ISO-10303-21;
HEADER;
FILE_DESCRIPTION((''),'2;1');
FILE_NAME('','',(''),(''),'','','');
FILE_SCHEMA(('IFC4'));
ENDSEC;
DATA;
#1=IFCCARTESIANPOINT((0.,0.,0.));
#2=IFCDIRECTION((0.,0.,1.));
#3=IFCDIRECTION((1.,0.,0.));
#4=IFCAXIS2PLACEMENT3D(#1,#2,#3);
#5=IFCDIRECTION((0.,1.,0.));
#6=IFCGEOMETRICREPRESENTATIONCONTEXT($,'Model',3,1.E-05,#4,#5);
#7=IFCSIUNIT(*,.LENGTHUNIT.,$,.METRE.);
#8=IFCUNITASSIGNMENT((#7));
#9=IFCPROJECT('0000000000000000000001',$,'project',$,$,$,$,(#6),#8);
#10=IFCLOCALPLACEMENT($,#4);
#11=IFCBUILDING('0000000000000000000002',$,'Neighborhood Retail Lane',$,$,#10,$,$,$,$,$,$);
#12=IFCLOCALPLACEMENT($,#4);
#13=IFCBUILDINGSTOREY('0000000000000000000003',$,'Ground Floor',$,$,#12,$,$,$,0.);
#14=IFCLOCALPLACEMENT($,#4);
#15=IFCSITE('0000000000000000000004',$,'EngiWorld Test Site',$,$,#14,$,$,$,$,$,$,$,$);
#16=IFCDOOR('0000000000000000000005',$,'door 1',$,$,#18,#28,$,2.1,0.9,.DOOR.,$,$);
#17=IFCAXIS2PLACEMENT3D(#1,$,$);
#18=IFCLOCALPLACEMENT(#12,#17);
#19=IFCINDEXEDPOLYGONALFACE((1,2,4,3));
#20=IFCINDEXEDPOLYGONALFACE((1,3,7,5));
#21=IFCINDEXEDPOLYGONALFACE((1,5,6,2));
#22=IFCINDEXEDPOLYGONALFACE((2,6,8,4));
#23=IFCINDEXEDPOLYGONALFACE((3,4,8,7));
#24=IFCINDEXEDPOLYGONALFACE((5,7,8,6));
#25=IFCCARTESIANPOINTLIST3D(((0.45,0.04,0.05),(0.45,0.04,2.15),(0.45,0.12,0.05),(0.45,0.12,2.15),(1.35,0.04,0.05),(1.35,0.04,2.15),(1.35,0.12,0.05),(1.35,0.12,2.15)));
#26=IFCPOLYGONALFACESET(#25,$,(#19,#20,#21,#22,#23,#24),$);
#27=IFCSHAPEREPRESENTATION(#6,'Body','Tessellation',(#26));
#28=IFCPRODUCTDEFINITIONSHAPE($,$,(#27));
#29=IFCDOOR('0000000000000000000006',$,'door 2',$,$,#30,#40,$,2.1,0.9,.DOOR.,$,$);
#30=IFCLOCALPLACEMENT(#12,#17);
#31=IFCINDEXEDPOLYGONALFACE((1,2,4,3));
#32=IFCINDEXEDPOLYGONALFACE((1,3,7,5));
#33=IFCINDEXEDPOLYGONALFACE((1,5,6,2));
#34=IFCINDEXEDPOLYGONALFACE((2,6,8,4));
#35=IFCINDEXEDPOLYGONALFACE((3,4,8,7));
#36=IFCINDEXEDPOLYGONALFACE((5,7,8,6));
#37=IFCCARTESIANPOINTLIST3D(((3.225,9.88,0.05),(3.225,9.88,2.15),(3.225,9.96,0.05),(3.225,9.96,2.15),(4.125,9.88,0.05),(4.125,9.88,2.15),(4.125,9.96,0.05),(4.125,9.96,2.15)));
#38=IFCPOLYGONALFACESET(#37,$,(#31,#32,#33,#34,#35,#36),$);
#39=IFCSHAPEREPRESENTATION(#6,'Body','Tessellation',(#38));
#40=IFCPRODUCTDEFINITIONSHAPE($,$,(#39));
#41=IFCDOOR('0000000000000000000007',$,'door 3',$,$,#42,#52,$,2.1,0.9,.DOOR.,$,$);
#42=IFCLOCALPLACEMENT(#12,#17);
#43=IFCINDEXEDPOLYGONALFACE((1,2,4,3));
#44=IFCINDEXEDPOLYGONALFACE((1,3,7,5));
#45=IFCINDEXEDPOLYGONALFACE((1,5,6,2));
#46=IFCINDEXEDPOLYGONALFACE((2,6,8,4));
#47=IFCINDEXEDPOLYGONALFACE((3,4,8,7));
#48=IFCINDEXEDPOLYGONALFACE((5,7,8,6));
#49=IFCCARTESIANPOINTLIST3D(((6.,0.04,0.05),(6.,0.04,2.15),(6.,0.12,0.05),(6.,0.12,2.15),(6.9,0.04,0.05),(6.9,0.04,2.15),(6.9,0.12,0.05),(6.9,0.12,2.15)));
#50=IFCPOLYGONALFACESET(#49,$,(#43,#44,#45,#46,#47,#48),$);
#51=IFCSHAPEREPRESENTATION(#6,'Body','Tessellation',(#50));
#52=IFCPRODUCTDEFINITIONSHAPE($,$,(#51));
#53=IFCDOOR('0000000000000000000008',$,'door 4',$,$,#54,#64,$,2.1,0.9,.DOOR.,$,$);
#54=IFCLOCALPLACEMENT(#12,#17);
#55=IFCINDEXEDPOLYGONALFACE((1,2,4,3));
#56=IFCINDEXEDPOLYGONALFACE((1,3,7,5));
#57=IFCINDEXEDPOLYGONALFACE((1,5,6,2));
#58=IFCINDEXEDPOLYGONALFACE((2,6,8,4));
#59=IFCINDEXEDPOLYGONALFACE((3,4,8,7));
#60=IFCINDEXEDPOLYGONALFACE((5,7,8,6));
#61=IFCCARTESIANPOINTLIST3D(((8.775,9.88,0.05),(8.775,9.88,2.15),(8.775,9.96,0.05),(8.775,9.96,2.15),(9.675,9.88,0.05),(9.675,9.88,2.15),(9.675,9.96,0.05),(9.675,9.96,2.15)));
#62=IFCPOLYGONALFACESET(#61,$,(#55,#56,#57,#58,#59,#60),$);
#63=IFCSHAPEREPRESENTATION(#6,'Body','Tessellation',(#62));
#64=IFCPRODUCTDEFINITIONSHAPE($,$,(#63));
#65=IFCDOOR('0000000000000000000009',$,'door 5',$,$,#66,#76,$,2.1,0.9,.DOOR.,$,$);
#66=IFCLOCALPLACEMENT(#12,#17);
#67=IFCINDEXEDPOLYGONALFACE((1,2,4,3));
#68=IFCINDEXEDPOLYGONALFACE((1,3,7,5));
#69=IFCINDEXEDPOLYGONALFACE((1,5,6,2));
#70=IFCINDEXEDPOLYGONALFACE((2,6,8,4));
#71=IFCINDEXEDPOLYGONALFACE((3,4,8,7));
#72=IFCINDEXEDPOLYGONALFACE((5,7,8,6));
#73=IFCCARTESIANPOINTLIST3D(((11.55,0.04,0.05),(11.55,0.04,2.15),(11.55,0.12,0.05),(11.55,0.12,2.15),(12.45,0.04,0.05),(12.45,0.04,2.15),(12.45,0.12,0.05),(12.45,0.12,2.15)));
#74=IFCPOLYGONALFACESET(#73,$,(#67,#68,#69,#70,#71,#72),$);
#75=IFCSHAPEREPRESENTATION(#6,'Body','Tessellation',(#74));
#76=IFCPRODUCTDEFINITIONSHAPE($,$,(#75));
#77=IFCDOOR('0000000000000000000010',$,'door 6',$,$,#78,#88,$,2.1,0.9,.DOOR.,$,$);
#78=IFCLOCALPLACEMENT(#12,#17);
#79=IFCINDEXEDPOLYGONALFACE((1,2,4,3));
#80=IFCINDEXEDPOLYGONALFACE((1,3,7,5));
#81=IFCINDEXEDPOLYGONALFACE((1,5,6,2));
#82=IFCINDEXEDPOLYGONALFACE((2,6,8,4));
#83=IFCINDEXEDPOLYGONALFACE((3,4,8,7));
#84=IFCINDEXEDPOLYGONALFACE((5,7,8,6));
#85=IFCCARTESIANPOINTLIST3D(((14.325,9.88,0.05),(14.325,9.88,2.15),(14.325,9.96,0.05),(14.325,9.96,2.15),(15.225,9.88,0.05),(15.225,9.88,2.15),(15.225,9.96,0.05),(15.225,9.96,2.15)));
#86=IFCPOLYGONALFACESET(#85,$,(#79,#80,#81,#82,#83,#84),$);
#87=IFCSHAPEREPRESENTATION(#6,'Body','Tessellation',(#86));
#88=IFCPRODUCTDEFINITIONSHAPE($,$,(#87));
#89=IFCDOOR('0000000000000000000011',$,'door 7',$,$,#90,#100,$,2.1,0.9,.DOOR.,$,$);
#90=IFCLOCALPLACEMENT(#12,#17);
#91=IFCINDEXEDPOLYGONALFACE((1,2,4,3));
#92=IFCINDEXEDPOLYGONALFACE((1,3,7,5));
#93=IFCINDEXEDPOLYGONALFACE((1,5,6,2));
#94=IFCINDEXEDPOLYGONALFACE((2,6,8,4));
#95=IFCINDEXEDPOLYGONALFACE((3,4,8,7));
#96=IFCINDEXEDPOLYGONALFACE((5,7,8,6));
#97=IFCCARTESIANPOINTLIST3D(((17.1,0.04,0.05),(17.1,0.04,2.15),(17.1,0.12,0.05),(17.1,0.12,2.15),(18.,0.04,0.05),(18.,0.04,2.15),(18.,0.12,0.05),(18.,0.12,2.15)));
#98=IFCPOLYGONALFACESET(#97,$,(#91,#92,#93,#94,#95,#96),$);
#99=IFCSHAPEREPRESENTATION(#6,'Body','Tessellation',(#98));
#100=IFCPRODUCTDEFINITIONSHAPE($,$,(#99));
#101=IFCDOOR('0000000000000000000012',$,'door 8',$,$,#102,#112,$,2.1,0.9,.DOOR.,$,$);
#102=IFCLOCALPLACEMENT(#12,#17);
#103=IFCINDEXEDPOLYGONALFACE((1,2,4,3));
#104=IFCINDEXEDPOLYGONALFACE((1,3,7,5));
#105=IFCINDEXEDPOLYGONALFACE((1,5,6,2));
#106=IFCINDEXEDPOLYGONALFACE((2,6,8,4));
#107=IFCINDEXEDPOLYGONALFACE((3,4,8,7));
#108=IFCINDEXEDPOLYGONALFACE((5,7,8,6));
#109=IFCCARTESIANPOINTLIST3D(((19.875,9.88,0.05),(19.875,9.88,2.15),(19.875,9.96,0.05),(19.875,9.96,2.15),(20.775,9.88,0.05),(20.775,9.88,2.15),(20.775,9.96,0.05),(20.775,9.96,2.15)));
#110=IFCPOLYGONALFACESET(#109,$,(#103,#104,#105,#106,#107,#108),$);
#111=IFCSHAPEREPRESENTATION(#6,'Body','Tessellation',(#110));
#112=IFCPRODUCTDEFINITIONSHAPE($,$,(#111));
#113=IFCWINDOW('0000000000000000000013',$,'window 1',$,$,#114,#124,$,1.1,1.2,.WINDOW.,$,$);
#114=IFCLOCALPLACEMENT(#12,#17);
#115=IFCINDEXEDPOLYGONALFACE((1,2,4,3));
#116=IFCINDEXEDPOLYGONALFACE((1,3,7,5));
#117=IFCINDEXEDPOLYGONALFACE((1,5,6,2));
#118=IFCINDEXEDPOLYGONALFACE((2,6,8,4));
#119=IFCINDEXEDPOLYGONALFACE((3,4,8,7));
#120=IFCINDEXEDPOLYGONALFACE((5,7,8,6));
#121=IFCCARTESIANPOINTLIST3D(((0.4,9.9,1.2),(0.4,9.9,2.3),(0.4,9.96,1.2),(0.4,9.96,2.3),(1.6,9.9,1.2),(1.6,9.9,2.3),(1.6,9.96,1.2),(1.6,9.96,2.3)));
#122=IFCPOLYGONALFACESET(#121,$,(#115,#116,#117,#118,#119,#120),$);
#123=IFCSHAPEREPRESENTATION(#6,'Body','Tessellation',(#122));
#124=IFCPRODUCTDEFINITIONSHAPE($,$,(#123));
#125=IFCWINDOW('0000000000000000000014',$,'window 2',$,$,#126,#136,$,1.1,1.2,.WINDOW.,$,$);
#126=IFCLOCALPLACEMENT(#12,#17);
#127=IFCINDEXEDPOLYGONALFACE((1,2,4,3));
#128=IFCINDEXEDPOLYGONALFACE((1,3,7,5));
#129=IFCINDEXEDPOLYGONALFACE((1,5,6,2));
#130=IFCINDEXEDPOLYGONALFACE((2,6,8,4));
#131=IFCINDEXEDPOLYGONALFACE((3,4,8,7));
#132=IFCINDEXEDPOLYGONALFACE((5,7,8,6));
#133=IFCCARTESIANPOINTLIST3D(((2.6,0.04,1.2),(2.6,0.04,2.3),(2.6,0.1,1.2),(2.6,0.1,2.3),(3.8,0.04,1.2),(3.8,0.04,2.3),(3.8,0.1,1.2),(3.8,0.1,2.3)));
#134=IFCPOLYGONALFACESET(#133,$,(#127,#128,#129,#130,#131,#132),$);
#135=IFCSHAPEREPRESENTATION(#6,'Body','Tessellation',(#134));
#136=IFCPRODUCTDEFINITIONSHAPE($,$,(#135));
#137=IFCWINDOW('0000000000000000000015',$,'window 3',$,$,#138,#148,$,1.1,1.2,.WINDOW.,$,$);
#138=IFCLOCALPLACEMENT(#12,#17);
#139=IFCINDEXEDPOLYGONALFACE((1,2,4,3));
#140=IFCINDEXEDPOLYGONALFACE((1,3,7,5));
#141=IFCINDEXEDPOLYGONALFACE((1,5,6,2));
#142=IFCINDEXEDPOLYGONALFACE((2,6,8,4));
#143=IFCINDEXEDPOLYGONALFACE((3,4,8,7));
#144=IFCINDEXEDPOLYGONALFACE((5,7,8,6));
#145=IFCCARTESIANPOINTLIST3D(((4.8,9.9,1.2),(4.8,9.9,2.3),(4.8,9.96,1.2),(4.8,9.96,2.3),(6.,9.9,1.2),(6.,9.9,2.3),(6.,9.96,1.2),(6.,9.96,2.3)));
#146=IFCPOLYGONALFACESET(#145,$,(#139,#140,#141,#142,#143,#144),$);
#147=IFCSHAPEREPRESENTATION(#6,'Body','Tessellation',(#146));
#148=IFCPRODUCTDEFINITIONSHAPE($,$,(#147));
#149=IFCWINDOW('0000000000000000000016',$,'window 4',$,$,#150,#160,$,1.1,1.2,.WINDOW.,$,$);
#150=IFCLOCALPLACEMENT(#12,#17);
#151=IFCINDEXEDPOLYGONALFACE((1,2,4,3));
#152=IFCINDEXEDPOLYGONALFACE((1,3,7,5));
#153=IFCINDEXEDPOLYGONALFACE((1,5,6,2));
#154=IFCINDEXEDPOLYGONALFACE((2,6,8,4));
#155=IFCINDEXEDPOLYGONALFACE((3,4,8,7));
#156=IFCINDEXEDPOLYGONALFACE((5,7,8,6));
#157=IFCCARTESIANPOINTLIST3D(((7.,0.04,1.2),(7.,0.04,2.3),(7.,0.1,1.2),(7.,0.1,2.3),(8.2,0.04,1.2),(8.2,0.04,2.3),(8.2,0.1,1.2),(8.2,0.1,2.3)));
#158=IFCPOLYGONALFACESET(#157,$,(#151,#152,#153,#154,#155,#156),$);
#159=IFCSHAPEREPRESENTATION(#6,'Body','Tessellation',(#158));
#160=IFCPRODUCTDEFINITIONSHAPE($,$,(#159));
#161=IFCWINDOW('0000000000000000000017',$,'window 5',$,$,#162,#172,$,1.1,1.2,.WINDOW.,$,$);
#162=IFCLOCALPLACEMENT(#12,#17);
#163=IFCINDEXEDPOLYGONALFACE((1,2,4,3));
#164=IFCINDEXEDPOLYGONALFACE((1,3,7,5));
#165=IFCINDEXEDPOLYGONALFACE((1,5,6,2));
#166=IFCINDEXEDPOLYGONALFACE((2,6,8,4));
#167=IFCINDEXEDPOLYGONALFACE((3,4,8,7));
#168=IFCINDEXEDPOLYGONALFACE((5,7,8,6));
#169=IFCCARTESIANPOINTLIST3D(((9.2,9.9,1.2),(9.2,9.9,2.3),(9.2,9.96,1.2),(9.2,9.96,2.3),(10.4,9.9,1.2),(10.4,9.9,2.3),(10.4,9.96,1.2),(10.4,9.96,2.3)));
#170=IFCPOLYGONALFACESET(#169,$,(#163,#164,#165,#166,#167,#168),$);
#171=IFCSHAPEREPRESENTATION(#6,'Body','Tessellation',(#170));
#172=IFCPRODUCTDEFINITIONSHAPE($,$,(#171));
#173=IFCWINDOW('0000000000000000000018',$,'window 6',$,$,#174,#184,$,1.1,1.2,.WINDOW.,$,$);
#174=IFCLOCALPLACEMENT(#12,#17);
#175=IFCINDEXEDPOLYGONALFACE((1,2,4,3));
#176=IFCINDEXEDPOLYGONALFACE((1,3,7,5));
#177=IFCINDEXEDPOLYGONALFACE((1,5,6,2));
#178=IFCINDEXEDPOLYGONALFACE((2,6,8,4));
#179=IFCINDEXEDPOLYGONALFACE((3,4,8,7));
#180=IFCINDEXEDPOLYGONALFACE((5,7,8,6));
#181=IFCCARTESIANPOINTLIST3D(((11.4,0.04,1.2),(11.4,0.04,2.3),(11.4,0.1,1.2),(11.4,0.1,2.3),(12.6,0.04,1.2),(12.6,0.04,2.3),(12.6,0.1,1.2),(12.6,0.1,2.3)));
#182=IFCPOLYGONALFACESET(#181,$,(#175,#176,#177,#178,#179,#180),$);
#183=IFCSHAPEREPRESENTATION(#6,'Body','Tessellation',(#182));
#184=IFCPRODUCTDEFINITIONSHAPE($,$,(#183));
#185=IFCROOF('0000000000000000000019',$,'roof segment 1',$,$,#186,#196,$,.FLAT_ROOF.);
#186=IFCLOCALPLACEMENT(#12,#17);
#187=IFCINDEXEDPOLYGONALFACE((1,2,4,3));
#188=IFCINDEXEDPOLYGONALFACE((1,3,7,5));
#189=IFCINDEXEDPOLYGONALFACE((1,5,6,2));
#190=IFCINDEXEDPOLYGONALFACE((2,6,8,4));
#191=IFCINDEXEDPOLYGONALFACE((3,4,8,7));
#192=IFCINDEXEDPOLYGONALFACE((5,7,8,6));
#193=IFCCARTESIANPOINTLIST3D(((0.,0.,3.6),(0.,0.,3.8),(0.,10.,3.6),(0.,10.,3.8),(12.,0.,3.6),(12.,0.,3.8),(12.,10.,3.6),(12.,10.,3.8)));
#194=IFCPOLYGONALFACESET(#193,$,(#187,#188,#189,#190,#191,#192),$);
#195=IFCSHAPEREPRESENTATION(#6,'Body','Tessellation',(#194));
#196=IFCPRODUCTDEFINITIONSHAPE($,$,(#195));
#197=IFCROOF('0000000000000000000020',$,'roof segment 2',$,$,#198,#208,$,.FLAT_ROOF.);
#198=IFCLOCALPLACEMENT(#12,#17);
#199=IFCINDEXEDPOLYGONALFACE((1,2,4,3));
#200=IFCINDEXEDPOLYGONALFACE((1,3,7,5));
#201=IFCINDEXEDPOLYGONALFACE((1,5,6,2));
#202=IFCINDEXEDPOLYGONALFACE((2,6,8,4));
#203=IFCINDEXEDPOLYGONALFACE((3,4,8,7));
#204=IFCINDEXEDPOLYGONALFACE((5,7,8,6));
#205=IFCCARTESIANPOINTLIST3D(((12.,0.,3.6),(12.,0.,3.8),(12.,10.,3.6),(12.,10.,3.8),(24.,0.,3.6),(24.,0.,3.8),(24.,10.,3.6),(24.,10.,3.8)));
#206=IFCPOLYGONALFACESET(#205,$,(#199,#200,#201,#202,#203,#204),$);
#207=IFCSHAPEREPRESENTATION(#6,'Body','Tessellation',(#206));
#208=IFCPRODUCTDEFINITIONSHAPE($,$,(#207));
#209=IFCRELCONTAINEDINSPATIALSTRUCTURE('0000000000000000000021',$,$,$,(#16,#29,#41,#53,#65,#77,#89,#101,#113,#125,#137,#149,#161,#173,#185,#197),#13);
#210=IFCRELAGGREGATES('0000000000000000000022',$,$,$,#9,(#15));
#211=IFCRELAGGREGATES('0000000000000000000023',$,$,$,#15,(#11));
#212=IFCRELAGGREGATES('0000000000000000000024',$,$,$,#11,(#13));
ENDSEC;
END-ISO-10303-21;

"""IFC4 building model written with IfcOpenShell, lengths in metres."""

from ifc_helpers import new_model, si_unit, direction, frame, origin_with_axes, origin_2d_with_axis, place, context, project, spatial, rectangle, extrude, element, save


model = new_model("IFC4")

# Units and contexts
model_context = context("Model", 3, precision=1e-05, world=origin_with_axes(), true_north=direction((0.0, 1.0, 0.0)))
ifc_project = project(units=[si_unit("LENGTHUNIT", "METRE")], contexts=[model_context])

# Site, building, storey
site_placement = place(None, origin_with_axes())
site = spatial("IfcSite", under=ifc_project, at=site_placement, Name="EngiWorld Test Site")
building_placement = place(None, origin_with_axes())
building = spatial("IfcBuilding", under=site, at=building_placement, Name="Neighborhood Retail Lane")
storey_placement = place(None, origin_with_axes())
storey = spatial("IfcBuildingStorey", under=building, at=storey_placement, Name="Ground Floor", Elevation=0.0)

# Doors
for number, where, z_axis, x_axis, name in (
    (1, (0.9, 0.08, 0.05), (0.0, 0.0, 1.0), (1.0, 0.0, 0.0), "door 1"),
    (2, (3.675, 9.92, 0.05), (0.0, 0.0, 1.0), (1.0, 0.0, 0.0), "door 2"),
    (3, (6.45, 0.08, 0.05), (0.0, 0.0, 1.0), (1.0, 0.0, 0.0), "door 3"),
    (4, (9.225, 9.92, 0.05), (0.0, 0.0, 1.0), (1.0, 0.0, 0.0), "door 4"),
    (5, (12.0, 0.08, 0.05), (0.0, 0.0, 1.0), (1.0, 0.0, 0.0), "door 5"),
    (6, (14.775, 9.92, 0.05), (0.0, 0.0, 1.0), (1.0, 0.0, 0.0), "door 6"),
    (7, (17.55, 0.08, 0.05), (0.0, 0.0, 1.0), (1.0, 0.0, 0.0), "door 7"),
    (8, (20.325, 9.92, 0.05), (0.0, 0.0, 1.0), (1.0, 0.0, 0.0), "door 8"),
):
    element("IfcDoor", number, at=place(None, frame(where, z_axis=z_axis, x_axis=x_axis)), inside=storey, Name=name, OverallHeight=2.1, OverallWidth=0.9, PredefinedType="DOOR", context=model_context, shape_type="SweptSolid", body=[
        extrude(rectangle(XDim=0.9, YDim=0.08, at=origin_2d_with_axis()), origin_with_axes(), (0.0, 0.0, 1.0), 2.1),
    ])

# Windows
for number, where, z_axis, x_axis, name in (
    (9, (1.0, 9.93, 1.2), (0.0, 0.0, 1.0), (1.0, 0.0, 0.0), "window 1"),
    (10, (3.2, 0.07, 1.2), (0.0, 0.0, 1.0), (1.0, 0.0, 0.0), "window 2"),
    (11, (5.4, 9.93, 1.2), (0.0, 0.0, 1.0), (1.0, 0.0, 0.0), "window 3"),
    (12, (7.6, 0.07, 1.2), (0.0, 0.0, 1.0), (1.0, 0.0, 0.0), "window 4"),
    (13, (9.8, 9.93, 1.2), (0.0, 0.0, 1.0), (1.0, 0.0, 0.0), "window 5"),
    (14, (12.0, 0.07, 1.2), (0.0, 0.0, 1.0), (1.0, 0.0, 0.0), "window 6"),
):
    element("IfcWindow", number, at=place(None, frame(where, z_axis=z_axis, x_axis=x_axis)), inside=storey, Name=name, OverallHeight=1.1, OverallWidth=1.2, PredefinedType="WINDOW", context=model_context, shape_type="SweptSolid", body=[
        extrude(rectangle(XDim=1.2, YDim=0.06, at=origin_2d_with_axis()), origin_with_axes(), (0.0, 0.0, 1.0), 1.1),
    ])

# Roofs
for number, where, z_axis, x_axis, name in (
    (15, (6.0, 5.0, 3.6), (0.0, 0.0, 1.0), (1.0, 0.0, 0.0), "roof segment 1"),
    (16, (18.0, 5.0, 3.6), (0.0, 0.0, 1.0), (1.0, 0.0, 0.0), "roof segment 2"),
):
    element("IfcRoof", number, at=place(None, frame(where, z_axis=z_axis, x_axis=x_axis)), inside=storey, Name=name, PredefinedType="FLAT_ROOF", context=model_context, shape_type="SweptSolid", body=[
        extrude(rectangle(XDim=12.0, YDim=10.0, at=origin_2d_with_axis()), origin_with_axes(), (0.0, 0.0, 1.0), 0.2),
    ])

save(model, "model.ifc")
